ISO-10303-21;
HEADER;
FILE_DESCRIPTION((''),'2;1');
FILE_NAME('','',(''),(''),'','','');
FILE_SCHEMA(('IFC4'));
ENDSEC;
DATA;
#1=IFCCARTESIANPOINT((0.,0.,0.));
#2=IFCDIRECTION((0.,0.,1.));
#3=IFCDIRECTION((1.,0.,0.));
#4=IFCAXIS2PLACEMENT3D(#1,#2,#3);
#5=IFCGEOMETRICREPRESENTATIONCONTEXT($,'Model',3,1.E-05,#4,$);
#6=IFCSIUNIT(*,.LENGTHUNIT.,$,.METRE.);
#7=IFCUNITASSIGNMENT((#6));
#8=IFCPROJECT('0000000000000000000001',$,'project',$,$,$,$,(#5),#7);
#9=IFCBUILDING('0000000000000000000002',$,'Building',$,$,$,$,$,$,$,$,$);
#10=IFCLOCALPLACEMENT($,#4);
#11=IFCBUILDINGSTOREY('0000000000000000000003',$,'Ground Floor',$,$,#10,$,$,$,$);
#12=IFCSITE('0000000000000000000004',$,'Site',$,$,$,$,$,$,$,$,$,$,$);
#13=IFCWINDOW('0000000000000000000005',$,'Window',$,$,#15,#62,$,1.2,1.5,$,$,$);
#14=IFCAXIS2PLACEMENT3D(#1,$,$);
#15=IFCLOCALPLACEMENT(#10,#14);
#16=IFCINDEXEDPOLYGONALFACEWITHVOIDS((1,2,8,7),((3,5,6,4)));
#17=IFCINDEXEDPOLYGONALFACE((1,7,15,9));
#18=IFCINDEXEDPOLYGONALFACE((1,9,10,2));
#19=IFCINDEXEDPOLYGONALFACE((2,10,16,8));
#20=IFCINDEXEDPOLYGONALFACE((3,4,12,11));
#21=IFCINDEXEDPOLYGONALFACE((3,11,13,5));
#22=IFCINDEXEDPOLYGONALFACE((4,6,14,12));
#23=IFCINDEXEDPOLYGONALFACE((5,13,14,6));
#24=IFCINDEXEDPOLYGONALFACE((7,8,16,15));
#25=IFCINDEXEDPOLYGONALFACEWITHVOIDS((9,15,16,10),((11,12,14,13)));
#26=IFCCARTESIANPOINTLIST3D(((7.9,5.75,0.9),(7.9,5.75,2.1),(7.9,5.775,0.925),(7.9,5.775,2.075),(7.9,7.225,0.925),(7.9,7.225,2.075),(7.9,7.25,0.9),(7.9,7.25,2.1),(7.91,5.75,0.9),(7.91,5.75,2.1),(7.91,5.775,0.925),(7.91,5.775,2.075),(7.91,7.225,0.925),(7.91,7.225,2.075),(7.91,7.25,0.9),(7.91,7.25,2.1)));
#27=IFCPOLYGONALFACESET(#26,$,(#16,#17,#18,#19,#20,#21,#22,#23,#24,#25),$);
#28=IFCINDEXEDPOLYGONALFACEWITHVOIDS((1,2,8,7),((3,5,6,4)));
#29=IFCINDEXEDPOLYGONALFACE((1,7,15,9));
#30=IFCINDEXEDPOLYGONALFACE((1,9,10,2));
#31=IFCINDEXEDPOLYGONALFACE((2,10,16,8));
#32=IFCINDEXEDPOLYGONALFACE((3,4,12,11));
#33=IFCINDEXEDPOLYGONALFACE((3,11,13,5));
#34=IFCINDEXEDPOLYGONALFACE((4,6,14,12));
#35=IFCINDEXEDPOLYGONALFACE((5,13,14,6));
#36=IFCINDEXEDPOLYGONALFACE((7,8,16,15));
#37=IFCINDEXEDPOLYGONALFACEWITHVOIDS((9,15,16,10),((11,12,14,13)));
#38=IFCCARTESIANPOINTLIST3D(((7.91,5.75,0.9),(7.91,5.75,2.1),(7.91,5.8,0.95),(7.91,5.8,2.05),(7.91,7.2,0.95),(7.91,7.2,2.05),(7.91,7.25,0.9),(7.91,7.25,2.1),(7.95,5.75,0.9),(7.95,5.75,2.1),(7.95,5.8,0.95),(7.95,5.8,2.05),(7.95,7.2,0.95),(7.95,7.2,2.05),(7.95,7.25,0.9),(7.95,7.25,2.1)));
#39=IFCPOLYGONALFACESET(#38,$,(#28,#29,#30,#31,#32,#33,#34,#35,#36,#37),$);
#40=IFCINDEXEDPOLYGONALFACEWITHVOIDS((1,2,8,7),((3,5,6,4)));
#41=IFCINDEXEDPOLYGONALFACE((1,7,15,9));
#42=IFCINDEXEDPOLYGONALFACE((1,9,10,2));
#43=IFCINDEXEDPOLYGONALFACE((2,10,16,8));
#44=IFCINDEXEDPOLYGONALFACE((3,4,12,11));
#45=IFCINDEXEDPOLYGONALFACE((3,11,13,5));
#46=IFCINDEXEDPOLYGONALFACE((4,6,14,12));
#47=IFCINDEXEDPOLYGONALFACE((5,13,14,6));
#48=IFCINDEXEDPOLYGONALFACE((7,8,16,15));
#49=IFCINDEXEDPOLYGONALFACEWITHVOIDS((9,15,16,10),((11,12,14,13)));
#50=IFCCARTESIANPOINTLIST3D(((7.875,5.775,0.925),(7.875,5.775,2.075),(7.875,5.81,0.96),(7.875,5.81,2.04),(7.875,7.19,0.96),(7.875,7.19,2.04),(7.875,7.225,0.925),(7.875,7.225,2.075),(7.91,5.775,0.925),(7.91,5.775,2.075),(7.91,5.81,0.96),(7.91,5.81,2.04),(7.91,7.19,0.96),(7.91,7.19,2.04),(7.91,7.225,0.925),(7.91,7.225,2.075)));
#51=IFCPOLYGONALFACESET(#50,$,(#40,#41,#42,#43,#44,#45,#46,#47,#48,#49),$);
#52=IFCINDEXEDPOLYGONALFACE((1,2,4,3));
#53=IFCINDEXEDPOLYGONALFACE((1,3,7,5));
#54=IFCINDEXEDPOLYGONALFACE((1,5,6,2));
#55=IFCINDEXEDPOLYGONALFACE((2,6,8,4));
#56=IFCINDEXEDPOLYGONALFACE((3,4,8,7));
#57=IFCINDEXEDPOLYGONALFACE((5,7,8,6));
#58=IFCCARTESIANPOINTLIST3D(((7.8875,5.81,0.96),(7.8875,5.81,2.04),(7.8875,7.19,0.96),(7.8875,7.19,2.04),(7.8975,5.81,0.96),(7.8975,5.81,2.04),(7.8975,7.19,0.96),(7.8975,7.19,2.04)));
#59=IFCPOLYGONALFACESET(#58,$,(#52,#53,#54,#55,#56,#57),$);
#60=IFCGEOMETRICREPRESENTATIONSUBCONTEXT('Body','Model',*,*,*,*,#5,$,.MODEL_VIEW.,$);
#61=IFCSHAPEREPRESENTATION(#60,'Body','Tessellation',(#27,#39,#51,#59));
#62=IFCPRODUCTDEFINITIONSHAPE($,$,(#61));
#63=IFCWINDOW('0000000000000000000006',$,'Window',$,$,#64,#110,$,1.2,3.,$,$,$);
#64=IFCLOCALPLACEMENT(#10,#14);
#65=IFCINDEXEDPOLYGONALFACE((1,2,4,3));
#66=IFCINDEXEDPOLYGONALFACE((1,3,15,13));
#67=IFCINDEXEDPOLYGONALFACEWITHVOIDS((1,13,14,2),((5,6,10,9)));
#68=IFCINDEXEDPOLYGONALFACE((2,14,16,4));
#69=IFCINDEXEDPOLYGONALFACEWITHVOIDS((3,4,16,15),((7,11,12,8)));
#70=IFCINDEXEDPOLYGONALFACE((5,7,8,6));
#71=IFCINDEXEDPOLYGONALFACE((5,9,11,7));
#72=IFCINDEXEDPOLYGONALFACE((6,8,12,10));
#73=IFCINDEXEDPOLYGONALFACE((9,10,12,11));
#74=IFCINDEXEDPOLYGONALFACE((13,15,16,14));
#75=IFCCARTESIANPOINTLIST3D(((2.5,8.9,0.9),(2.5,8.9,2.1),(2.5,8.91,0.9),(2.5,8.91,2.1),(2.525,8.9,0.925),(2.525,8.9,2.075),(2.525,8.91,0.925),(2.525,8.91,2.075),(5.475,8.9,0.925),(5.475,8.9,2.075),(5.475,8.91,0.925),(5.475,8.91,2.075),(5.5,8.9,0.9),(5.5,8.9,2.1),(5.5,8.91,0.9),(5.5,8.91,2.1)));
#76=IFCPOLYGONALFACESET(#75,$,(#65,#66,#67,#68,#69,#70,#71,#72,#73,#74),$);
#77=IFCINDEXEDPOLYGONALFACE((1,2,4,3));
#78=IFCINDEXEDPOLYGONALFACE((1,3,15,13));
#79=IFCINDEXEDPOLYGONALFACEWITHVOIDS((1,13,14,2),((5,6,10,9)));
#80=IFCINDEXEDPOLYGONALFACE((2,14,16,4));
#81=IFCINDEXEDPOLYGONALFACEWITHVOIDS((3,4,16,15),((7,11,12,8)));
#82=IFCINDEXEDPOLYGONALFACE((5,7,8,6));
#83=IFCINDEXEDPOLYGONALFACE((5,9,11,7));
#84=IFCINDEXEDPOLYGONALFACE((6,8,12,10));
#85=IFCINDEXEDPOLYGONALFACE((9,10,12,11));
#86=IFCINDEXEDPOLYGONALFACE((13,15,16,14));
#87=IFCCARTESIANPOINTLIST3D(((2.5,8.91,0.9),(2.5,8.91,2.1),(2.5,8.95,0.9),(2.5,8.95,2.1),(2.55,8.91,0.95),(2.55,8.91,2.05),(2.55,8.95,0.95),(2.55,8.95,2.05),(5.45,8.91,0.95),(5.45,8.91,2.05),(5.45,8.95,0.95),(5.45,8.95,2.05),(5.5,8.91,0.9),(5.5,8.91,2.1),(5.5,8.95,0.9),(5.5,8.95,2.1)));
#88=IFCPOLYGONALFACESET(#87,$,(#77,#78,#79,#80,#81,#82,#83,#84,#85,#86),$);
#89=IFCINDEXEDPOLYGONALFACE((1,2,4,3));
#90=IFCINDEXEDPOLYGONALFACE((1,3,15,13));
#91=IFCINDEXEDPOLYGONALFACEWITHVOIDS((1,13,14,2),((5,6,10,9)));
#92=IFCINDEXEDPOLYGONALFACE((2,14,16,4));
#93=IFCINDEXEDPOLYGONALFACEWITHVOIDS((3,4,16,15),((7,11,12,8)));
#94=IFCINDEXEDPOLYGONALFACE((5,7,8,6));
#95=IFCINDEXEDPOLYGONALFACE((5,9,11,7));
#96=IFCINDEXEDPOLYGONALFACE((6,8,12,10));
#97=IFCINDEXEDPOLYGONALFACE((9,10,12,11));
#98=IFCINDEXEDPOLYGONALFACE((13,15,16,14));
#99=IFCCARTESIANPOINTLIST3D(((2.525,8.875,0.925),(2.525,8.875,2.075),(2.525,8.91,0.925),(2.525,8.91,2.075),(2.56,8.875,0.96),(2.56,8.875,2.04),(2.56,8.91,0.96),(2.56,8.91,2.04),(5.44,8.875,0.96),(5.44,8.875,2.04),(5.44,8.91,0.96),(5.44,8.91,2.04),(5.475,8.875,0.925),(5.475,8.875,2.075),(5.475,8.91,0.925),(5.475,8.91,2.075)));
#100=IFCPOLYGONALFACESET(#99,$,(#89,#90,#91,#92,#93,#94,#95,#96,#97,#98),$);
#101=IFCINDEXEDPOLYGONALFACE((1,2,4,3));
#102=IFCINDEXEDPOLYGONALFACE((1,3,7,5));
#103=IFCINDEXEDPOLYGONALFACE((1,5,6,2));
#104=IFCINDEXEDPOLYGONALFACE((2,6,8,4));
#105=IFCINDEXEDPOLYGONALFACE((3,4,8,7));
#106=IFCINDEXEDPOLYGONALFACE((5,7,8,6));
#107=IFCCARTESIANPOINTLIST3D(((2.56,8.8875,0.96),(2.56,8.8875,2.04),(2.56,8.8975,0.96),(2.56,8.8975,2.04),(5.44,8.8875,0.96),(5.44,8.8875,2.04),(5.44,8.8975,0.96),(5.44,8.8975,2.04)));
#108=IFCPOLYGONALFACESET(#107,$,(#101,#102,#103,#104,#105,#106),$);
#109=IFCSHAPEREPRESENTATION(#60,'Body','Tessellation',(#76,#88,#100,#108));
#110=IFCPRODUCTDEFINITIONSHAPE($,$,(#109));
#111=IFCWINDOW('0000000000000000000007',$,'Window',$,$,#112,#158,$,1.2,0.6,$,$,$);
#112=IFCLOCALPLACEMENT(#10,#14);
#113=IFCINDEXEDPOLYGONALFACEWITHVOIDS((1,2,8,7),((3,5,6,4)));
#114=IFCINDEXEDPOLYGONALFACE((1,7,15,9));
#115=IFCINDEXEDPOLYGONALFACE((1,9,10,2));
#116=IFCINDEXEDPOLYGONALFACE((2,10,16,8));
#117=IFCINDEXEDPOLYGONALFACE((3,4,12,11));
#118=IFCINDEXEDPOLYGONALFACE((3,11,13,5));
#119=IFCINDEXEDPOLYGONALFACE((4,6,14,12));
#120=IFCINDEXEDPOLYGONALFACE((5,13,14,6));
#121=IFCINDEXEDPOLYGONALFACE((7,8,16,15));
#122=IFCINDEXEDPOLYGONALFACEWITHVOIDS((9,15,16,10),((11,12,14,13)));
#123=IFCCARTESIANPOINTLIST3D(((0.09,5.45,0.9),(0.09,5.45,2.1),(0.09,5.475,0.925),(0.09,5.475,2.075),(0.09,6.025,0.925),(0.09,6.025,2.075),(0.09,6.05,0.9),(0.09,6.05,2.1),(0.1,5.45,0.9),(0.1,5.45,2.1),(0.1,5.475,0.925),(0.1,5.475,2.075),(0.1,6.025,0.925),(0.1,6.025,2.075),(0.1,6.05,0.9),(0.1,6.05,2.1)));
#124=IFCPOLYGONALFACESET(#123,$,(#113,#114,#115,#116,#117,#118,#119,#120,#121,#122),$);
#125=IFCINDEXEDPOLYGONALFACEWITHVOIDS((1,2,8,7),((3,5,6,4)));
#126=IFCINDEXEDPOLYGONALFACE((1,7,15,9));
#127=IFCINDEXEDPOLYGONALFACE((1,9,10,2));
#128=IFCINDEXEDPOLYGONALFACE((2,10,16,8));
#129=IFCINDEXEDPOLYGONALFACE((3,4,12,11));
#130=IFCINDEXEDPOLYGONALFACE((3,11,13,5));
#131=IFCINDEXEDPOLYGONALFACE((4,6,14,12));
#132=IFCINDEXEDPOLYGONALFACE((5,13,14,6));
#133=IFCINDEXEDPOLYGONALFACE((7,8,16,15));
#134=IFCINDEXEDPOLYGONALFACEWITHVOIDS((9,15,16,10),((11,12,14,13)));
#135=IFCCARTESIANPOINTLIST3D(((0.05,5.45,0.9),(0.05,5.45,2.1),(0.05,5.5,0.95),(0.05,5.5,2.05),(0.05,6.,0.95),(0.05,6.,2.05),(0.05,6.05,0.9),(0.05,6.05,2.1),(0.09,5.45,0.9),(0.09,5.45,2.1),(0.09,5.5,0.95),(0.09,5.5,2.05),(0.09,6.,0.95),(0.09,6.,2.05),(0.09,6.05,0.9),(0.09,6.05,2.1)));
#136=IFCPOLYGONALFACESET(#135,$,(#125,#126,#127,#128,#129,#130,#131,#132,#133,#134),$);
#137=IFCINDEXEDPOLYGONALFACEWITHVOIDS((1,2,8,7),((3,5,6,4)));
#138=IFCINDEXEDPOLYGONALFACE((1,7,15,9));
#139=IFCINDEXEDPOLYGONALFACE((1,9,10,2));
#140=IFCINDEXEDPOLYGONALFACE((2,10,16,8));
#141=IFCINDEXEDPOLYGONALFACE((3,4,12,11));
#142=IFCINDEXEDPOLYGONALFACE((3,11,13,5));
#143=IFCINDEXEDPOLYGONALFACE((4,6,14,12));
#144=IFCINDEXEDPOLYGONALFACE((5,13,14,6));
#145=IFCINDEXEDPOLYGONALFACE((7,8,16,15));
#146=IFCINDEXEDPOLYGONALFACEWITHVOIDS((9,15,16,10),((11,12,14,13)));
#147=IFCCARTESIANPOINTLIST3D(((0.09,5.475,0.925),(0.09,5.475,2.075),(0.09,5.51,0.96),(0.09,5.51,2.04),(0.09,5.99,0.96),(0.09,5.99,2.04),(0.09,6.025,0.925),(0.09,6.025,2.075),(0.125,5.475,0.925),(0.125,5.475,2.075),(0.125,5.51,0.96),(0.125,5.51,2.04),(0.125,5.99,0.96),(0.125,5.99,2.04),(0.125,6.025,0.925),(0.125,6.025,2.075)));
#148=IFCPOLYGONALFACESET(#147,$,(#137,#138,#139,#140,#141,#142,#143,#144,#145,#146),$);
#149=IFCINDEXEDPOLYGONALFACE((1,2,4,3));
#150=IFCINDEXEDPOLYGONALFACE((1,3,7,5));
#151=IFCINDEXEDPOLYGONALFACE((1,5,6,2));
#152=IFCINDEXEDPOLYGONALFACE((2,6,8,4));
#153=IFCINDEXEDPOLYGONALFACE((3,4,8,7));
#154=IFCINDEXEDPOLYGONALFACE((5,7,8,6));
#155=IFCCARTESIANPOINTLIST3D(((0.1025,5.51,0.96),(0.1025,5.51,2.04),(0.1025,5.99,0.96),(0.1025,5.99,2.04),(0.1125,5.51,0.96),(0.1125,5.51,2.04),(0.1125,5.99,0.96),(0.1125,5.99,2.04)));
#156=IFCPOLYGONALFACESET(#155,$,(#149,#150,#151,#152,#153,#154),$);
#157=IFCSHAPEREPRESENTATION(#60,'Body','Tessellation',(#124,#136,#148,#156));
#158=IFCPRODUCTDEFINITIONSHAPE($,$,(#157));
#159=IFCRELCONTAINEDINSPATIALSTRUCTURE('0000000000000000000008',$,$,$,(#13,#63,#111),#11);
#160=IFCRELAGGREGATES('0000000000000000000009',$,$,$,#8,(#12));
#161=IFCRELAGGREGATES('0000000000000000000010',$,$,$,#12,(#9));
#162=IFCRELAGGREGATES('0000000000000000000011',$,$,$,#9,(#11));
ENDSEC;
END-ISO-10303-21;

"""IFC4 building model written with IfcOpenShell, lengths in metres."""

from ifc_helpers import new_model, si_unit, frame, origin_with_axes, place, context, subcontext, project, spatial, line, indexed_curve, outline, extrude, element, save


model = new_model("IFC4")

# Units and contexts
model_context = context("Model", 3, precision=1e-05, world=origin_with_axes())
body_context = subcontext(model_context, "Body", "Model", "MODEL_VIEW")
ifc_project = project(units=[si_unit("LENGTHUNIT", "METRE")], contexts=[model_context])

# Site, building, storey
site = spatial("IfcSite", under=ifc_project, Name="Site")
building = spatial("IfcBuilding", under=site, Name="Building")
storey_placement = place(None, origin_with_axes())
storey = spatial("IfcBuildingStorey", under=building, at=storey_placement, Name="Ground Floor")

# Windows
for number, where, z_axis, x_axis, name in (
    (1, (8.0, 5.75, 0.9), (0.0, 0.0, 1.0), (0.0, 1.0, 0.0), "Window"),
):
    element("IfcWindow", number, at=place(storey_placement, frame(where, z_axis=z_axis, x_axis=x_axis)), inside=storey, Name=name, OverallHeight=1.2, OverallWidth=1.5, context=body_context, shape_type="SweptSolid", body=[
        extrude(outline(indexed_curve([(0.0, 0.0), (1.5, 0.0), (1.5, 1.2), (0.0, 1.2)], segments=[line(1, 2, 3, 4, 1)]), holes=[indexed_curve([(0.025, 0.025), (1.475, 0.025), (1.475, 1.175), (0.025, 1.175)], segments=[line(1, 2, 3, 4, 1)])]), frame((0.0, 0.09, 0.0), z_axis=(0.0, -1.0, 0.0), x_axis=(1.0, 0.0, 0.0)), (0.0, 0.0, -1.0), 0.01),
        extrude(outline(indexed_curve([(0.0, 0.0), (1.5, 0.0), (1.5, 1.2), (0.0, 1.2)], segments=[line(1, 2, 3, 4, 1)]), holes=[indexed_curve([(0.05, 0.05), (1.45, 0.05), (1.45, 1.15), (0.05, 1.15)], segments=[line(1, 2, 3, 4, 1)])]), frame((0.0, 0.05, 0.0), z_axis=(0.0, -1.0, 0.0), x_axis=(1.0, 0.0, 0.0)), (0.0, 0.0, -1.0), 0.04),
        extrude(outline(indexed_curve([(0.0, 0.0), (1.45, 0.0), (1.45, 1.15), (0.0, 1.15)], segments=[line(1, 2, 3, 4, 1)]), holes=[indexed_curve([(0.035, 0.035), (1.415, 0.035), (1.415, 1.115), (0.035, 1.115)], segments=[line(1, 2, 3, 4, 1)])]), frame((0.025, 0.09, 0.025), z_axis=(0.0, -1.0, 0.0), x_axis=(1.0, 0.0, 0.0)), (0.0, 0.0, -1.0), 0.035),
        extrude(outline(indexed_curve([(0.035, 0.035), (1.415, 0.035), (1.415, 1.115), (0.035, 1.115)], segments=[line(1, 2, 3, 4, 1)])), frame((0.025, 0.1025, 0.025), z_axis=(0.0, -1.0, 0.0), x_axis=(1.0, 0.0, 0.0)), (0.0, 0.0, -1.0), 0.01),
    ])
window_1_placement = place(storey_placement, frame((5.5, 9.0, 0.9), z_axis=(0.0, 0.0, 1.0), x_axis=(-1.0, 0.0, 0.0)))
element("IfcWindow", 2, at=window_1_placement, inside=storey, Name="Window", OverallHeight=1.2, OverallWidth=3.0, context=body_context, shape_type="SweptSolid", body=[
    extrude(outline(indexed_curve([(0.0, 0.0), (3.0, 0.0), (3.0, 1.2), (0.0, 1.2)], segments=[line(1, 2, 3, 4, 1)]), holes=[indexed_curve([(0.025, 0.025), (2.975, 0.025), (2.975, 1.175), (0.025, 1.175)], segments=[line(1, 2, 3, 4, 1)])]), frame((0.0, 0.09, 0.0), z_axis=(0.0, -1.0, 0.0), x_axis=(1.0, 0.0, 0.0)), (0.0, 0.0, -1.0), 0.01),
    extrude(outline(indexed_curve([(0.0, 0.0), (3.0, 0.0), (3.0, 1.2), (0.0, 1.2)], segments=[line(1, 2, 3, 4, 1)]), holes=[indexed_curve([(0.05, 0.05), (2.95, 0.05), (2.95, 1.15), (0.05, 1.15)], segments=[line(1, 2, 3, 4, 1)])]), frame((0.0, 0.05, 0.0), z_axis=(0.0, -1.0, 0.0), x_axis=(1.0, 0.0, 0.0)), (0.0, 0.0, -1.0), 0.04),
    extrude(outline(indexed_curve([(0.0, 0.0), (2.95, 0.0), (2.95, 1.15), (0.0, 1.15)], segments=[line(1, 2, 3, 4, 1)]), holes=[indexed_curve([(0.035, 0.035), (2.915, 0.035), (2.915, 1.115), (0.035, 1.115)], segments=[line(1, 2, 3, 4, 1)])]), frame((0.025, 0.09, 0.025), z_axis=(0.0, -1.0, 0.0), x_axis=(1.0, 0.0, 0.0)), (0.0, 0.0, -1.0), 0.035),
    extrude(outline(indexed_curve([(0.035, 0.035), (2.915, 0.035), (2.915, 1.115), (0.035, 1.115)], segments=[line(1, 2, 3, 4, 1)])), frame((0.025, 0.1025, 0.025), z_axis=(0.0, -1.0, 0.0), x_axis=(1.0, 0.0, 0.0)), (0.0, 0.0, -1.0), 0.01),
])
window_2_placement = place(storey_placement, frame((0.0, 6.05, 0.9), z_axis=(0.0, 0.0, 1.0), x_axis=(0.0, -1.0, 0.0)))
element("IfcWindow", 3, at=window_2_placement, inside=storey, Name="Window", OverallHeight=1.2, OverallWidth=0.6, context=body_context, shape_type="SweptSolid", body=[
    extrude(outline(indexed_curve([(0.0, 0.0), (0.6, 0.0), (0.6, 1.2), (0.0, 1.2)], segments=[line(1, 2, 3, 4, 1)]), holes=[indexed_curve([(0.025, 0.025), (0.575, 0.025), (0.575, 1.175), (0.025, 1.175)], segments=[line(1, 2, 3, 4, 1)])]), frame((0.0, 0.09, 0.0), z_axis=(0.0, -1.0, 0.0), x_axis=(1.0, 0.0, 0.0)), (0.0, 0.0, -1.0), 0.01),
    extrude(outline(indexed_curve([(0.0, 0.0), (0.6, 0.0), (0.6, 1.2), (0.0, 1.2)], segments=[line(1, 2, 3, 4, 1)]), holes=[indexed_curve([(0.05, 0.05), (0.55, 0.05), (0.55, 1.15), (0.05, 1.15)], segments=[line(1, 2, 3, 4, 1)])]), frame((0.0, 0.05, 0.0), z_axis=(0.0, -1.0, 0.0), x_axis=(1.0, 0.0, 0.0)), (0.0, 0.0, -1.0), 0.04),
    extrude(outline(indexed_curve([(0.0, 0.0), (0.55, 0.0), (0.55, 1.15), (0.0, 1.15)], segments=[line(1, 2, 3, 4, 1)]), holes=[indexed_curve([(0.035, 0.035), (0.515, 0.035), (0.515, 1.115), (0.035, 1.115)], segments=[line(1, 2, 3, 4, 1)])]), frame((0.025, 0.09, 0.025), z_axis=(0.0, -1.0, 0.0), x_axis=(1.0, 0.0, 0.0)), (0.0, 0.0, -1.0), 0.035),
    extrude(outline(indexed_curve([(0.035, 0.035), (0.515, 0.035), (0.515, 1.115), (0.035, 1.115)], segments=[line(1, 2, 3, 4, 1)])), frame((0.025, 0.1025, 0.025), z_axis=(0.0, -1.0, 0.0), x_axis=(1.0, 0.0, 0.0)), (0.0, 0.0, -1.0), 0.01),
])

save(model, "model.ifc")
